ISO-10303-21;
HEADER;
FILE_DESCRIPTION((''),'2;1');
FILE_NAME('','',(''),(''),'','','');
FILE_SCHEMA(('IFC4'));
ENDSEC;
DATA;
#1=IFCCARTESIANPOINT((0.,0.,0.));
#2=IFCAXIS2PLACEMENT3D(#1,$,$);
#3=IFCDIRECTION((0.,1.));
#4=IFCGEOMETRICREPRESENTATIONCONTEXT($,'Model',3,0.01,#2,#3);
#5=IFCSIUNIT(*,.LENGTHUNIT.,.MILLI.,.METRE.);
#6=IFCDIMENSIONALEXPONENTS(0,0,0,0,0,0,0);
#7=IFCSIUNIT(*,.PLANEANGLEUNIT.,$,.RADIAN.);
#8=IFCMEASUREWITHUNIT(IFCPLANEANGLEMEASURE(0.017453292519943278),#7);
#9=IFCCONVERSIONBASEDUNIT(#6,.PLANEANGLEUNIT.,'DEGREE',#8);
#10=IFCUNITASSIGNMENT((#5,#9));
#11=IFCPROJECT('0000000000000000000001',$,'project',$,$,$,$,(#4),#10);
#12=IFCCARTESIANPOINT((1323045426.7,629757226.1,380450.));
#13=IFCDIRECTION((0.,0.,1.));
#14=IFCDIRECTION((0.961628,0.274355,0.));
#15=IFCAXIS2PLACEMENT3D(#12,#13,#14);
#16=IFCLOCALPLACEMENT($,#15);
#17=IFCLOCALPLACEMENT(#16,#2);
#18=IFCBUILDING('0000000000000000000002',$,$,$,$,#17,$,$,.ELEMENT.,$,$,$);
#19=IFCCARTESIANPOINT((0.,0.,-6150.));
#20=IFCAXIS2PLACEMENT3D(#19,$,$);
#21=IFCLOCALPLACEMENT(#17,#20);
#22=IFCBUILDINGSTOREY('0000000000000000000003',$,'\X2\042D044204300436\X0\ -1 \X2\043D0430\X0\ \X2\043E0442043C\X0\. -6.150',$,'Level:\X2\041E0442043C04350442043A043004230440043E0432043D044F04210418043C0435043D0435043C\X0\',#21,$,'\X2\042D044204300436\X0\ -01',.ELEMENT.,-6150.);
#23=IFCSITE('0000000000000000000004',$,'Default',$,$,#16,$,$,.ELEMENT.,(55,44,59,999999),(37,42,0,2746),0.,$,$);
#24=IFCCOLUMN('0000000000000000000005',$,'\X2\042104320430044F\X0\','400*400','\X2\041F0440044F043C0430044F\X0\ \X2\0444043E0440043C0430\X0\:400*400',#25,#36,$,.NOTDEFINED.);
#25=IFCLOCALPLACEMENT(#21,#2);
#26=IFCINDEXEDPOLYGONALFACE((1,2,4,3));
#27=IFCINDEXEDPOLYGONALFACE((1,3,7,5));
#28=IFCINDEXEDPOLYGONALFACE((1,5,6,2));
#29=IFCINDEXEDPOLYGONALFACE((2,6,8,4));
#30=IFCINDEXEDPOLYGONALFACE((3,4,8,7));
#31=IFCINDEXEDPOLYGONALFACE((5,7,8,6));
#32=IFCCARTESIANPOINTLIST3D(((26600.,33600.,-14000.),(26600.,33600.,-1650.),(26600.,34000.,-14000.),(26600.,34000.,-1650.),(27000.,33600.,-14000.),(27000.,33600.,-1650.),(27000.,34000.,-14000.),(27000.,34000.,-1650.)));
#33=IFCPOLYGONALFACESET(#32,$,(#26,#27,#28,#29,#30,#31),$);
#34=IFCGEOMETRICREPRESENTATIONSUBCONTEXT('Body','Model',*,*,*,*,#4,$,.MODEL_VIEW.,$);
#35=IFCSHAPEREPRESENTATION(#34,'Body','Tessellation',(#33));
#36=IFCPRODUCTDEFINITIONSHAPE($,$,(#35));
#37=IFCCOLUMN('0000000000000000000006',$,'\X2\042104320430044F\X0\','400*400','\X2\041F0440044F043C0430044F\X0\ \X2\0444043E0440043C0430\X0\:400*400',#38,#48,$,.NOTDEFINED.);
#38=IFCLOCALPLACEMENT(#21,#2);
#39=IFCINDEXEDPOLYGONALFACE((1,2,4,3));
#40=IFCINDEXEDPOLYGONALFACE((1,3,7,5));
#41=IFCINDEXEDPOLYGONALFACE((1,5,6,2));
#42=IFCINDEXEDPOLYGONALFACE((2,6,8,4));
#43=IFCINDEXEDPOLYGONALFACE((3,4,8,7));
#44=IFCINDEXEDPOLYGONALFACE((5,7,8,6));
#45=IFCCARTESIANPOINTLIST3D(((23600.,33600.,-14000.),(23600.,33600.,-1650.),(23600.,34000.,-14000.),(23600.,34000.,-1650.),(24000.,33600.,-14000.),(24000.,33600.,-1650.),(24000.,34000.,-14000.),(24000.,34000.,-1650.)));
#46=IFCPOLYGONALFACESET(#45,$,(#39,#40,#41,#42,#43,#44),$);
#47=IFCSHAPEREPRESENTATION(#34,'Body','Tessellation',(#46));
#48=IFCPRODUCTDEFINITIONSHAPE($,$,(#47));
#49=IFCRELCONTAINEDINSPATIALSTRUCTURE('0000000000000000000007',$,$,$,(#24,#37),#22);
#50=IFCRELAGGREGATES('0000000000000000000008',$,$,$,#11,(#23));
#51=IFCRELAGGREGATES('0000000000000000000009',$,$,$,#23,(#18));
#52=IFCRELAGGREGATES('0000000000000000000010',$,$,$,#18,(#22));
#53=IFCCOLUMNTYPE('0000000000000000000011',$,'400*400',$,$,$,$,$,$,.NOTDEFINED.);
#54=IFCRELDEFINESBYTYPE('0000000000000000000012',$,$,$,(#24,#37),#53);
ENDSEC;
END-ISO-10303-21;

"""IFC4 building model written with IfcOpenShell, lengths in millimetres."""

from ifc_helpers import new_model, entity, si_unit, converted_unit, direction, frame, origin, place, context, subcontext, project, spatial, indexed_curve, outline, extrude, type_object, element, save


model = new_model("IFC4")

# Units and contexts
model_context = context("Model", 3, precision=0.01, world=origin(), true_north=direction((0.0, 1.0)))
body_context = subcontext(model_context, "Body", "Model", "MODEL_VIEW")
ifc_project = project(units=[si_unit("LENGTHUNIT", "METRE", prefix="MILLI"), converted_unit("PLANEANGLEUNIT", "DEGREE", entity("IfcPlaneAngleMeasure", 0.017453292519943278), si_unit("PLANEANGLEUNIT", "RADIAN"), dimensions=[0, 0, 0, 0, 0, 0, 0])], contexts=[model_context])

# Site, building, storey
site_placement = place(None, frame((1323045426.7, 629757226.1, 380450.0), z_axis=(0.0, 0.0, 1.0), x_axis=(0.961628, 0.274355, 0.0)))
site = spatial("IfcSite", under=ifc_project, at=site_placement, Name="Default", CompositionType="ELEMENT", RefLatitude=(55, 44, 59, 999999), RefLongitude=(37, 42, 0, 2746), RefElevation=0.0)
building_placement = place(site_placement, origin())
building = spatial("IfcBuilding", under=site, at=building_placement, CompositionType="ELEMENT")
storey_placement = place(building_placement, frame((0.0, 0.0, -6150.0)))
storey = spatial("IfcBuildingStorey", under=building, at=storey_placement, Name="Этаж -1 на отм. -6.150", ObjectType="Level:ОтметкаУровняСИменем", LongName="Этаж -01", CompositionType="ELEMENT", Elevation=-6150.0)

# Columns
column_type = type_object("IfcColumnType", Name="400*400", PredefinedType="NOTDEFINED")
column_1_placement = place(storey_placement, origin())
element("IfcColumn", 1, at=column_1_placement, inside=storey, type_object=column_type, Name="Свая", Description="400*400", ObjectType="Прямая форма:400*400", PredefinedType="NOTDEFINED", context=body_context, shape_type="SweptSolid", body=[
    extrude(outline(indexed_curve([(-200.0, -200.0), (200.0, -200.0), (200.0, 200.0), (-200.0, 200.0), (-200.0, -200.0)], self_intersect=False)), frame((26800.0, 33800.0, -14000.0), z_axis=(0.0, 0.0, 1.0), x_axis=(0.0, 1.0, 0.0)), (0.0, 0.0, 1.0), 12350.0),
])
column_2_placement = place(storey_placement, origin())
element("IfcColumn", 2, at=column_2_placement, inside=storey, type_object=column_type, Name="Свая", Description="400*400", ObjectType="Прямая форма:400*400", PredefinedType="NOTDEFINED", context=body_context, shape_type="SweptSolid", body=[
    extrude(outline(indexed_curve([(-200.0, -200.0), (200.0, -200.0), (200.0, 200.0), (-200.0, 200.0), (-200.0, -200.0)], self_intersect=False)), frame((23800.0, 33800.0, -14000.0), z_axis=(0.0, 0.0, 1.0), x_axis=(0.0, 1.0, 0.0)), (0.0, 0.0, 1.0), 12350.0),
])

save(model, "model.ifc")
